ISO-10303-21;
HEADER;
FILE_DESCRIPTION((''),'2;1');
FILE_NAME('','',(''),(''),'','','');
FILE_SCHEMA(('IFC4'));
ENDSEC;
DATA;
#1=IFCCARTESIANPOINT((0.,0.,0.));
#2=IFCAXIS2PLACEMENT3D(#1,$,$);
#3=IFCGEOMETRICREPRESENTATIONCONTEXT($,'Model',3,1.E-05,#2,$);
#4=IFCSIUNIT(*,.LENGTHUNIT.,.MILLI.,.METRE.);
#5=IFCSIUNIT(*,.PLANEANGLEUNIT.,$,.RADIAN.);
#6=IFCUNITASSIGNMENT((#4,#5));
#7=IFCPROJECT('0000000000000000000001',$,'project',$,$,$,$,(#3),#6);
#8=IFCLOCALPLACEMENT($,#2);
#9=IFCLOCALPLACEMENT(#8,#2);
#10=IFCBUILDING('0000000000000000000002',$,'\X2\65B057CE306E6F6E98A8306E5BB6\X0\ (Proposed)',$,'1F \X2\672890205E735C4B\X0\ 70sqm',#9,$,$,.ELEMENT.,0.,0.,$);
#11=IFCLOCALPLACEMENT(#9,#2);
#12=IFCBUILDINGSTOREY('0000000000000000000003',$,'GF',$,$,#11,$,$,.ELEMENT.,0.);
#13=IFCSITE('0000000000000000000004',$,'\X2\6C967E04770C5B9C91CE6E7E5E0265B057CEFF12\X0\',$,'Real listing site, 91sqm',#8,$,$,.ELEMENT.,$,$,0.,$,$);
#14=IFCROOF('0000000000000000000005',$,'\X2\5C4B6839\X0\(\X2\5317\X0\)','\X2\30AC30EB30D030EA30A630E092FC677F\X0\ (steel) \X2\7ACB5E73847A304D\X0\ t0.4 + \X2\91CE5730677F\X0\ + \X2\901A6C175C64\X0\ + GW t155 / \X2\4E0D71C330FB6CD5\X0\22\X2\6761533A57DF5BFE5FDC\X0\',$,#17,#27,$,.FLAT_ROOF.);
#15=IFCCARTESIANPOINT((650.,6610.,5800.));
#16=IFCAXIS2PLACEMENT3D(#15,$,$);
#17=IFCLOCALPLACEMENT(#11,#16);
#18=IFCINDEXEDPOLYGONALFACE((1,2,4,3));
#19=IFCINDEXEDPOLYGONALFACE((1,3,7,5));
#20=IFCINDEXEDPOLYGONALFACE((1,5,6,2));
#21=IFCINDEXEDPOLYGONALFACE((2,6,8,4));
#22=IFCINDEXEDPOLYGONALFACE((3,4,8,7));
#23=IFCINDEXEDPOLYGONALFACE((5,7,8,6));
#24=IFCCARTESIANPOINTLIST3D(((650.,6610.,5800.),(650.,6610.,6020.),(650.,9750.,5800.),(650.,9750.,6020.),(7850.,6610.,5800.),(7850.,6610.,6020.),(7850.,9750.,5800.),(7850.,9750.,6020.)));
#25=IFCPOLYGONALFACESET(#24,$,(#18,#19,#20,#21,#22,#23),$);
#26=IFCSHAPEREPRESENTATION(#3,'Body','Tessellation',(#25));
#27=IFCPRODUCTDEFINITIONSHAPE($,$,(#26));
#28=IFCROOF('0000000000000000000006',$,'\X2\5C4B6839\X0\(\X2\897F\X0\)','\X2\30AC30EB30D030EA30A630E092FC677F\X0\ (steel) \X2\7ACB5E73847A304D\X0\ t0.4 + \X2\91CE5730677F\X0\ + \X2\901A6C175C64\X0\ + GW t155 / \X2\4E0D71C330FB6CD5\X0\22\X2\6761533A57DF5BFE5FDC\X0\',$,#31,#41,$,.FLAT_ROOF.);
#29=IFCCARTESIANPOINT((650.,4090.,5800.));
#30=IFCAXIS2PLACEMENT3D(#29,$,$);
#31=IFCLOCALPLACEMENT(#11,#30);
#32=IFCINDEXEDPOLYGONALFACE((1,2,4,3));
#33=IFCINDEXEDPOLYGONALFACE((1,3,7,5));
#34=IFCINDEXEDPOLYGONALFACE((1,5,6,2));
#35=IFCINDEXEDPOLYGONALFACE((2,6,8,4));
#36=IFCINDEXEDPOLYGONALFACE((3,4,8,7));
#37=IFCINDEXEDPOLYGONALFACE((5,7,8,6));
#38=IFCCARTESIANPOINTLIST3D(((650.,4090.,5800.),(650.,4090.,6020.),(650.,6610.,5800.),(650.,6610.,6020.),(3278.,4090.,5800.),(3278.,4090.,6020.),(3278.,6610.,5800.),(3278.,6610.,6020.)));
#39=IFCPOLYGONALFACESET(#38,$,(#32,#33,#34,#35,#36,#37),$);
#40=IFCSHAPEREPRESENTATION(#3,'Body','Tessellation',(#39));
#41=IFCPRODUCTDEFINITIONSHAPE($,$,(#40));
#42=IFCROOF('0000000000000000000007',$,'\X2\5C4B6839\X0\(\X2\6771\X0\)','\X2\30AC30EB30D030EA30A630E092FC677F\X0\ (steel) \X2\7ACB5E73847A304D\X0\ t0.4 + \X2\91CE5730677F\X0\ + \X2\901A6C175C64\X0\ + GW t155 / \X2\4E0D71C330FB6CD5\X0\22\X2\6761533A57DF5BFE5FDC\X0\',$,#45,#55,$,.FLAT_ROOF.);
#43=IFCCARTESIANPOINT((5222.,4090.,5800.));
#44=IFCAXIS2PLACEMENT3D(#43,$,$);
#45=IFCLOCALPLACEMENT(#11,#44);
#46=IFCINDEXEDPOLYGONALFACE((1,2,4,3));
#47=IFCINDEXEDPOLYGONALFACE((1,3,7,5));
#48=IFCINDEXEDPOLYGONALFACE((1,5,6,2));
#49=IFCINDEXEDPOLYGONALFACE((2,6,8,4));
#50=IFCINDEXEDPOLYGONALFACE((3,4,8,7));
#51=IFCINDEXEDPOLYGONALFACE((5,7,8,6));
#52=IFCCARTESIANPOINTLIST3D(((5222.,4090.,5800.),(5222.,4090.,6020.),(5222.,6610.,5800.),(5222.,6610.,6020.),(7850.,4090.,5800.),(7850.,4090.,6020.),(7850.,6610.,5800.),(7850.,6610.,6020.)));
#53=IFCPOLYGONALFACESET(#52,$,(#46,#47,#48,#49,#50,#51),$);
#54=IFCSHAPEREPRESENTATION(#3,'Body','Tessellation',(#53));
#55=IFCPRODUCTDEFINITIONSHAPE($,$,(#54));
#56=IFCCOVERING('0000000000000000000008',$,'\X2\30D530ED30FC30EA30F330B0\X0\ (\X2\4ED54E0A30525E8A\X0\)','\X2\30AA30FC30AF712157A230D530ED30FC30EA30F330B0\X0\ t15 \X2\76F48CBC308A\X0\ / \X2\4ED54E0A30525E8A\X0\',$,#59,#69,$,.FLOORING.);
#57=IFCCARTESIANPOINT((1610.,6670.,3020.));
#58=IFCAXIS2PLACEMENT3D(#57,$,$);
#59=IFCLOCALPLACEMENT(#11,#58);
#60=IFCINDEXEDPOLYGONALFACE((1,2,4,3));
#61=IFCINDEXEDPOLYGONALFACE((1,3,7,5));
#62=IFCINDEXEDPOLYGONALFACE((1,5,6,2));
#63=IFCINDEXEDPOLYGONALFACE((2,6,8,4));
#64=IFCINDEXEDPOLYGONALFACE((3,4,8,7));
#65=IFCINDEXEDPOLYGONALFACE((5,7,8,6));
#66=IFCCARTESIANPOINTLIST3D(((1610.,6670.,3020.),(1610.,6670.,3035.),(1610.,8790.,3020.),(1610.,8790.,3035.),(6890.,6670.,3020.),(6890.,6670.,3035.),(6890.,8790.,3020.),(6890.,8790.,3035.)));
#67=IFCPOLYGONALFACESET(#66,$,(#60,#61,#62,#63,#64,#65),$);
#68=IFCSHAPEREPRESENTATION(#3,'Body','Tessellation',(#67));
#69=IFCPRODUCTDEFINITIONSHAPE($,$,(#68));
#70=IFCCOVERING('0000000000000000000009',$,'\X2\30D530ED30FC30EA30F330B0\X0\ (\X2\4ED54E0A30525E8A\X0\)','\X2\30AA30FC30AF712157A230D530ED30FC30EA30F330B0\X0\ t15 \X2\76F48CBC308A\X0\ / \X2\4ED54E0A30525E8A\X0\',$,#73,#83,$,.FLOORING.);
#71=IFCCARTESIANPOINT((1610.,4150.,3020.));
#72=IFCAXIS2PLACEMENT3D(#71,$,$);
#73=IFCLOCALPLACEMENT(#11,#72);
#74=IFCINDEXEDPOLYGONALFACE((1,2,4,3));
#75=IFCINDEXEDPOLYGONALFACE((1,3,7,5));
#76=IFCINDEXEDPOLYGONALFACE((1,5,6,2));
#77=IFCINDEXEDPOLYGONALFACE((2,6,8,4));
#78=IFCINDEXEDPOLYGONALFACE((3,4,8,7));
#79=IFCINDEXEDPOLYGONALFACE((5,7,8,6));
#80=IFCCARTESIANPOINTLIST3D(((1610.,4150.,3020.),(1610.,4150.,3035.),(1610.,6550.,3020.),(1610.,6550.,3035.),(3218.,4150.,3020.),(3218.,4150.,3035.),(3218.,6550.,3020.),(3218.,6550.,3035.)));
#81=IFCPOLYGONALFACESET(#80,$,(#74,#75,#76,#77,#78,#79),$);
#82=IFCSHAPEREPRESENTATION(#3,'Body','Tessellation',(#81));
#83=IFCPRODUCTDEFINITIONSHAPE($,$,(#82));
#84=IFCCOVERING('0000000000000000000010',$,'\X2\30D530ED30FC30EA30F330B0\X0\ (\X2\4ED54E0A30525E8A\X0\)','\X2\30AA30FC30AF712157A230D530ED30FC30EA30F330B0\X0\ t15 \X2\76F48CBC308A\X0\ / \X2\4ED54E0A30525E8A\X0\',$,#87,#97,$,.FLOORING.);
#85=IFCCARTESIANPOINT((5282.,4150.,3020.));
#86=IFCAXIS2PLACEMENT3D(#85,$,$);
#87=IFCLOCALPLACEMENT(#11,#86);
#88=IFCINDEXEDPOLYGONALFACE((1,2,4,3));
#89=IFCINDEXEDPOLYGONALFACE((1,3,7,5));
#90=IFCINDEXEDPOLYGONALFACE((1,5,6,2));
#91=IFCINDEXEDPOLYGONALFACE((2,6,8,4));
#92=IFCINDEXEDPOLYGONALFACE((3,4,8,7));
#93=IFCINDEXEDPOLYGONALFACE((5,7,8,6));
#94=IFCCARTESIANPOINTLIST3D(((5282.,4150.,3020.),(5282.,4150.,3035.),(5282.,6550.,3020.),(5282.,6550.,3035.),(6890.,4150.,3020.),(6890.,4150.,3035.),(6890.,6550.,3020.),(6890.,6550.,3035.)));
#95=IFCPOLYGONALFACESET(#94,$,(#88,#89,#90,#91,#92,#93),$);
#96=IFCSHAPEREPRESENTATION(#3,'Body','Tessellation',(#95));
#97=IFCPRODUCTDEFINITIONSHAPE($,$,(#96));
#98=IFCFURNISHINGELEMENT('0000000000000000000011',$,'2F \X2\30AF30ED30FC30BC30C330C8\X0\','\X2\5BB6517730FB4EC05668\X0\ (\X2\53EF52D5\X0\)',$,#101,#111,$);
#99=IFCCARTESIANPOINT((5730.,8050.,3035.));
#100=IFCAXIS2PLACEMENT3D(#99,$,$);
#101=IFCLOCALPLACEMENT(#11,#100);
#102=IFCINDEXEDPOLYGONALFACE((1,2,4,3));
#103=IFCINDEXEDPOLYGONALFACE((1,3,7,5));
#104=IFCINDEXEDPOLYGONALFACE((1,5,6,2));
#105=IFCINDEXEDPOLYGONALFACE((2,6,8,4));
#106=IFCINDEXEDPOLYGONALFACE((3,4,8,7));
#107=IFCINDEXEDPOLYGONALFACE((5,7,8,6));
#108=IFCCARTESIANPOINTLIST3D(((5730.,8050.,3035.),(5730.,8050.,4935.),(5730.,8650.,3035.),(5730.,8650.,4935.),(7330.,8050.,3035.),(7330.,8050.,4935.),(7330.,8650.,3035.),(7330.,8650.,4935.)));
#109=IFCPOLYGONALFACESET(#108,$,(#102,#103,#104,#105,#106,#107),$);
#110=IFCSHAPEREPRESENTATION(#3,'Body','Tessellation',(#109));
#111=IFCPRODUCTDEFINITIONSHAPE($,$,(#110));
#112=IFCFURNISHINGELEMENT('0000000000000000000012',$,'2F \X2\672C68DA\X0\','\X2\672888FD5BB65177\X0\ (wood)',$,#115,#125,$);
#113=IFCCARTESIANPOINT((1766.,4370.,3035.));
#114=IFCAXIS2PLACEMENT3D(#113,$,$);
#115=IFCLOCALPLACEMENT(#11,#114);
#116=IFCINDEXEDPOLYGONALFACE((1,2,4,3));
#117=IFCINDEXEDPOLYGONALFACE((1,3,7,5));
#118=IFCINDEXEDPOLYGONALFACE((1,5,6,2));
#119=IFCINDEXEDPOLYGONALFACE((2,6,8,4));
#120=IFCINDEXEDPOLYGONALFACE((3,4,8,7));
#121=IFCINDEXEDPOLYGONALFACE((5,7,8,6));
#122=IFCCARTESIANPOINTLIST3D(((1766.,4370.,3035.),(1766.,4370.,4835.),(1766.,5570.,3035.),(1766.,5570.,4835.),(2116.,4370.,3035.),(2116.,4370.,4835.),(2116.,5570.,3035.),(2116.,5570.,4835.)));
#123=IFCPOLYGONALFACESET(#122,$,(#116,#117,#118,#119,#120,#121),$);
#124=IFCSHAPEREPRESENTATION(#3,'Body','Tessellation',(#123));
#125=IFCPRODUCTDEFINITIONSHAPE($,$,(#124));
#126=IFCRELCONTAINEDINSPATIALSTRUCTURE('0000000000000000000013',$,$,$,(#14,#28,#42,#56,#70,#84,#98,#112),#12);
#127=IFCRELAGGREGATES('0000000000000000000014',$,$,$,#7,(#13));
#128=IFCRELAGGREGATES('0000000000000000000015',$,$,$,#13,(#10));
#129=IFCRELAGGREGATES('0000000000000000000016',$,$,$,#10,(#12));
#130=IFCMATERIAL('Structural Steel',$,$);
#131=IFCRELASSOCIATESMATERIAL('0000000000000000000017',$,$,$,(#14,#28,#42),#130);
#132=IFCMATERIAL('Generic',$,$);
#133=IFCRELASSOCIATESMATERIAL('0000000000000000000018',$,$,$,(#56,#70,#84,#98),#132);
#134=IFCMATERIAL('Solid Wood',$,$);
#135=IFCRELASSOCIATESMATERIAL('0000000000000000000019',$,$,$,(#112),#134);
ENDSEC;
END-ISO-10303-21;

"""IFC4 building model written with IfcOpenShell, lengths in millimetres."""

from ifc_helpers import new_model, si_unit, frame, frame_2d, origin, place, context, project, spatial, rectangle, extrude, material, element, save


model = new_model("IFC4")

# Units and contexts
model_context = context("Model", 3, precision=1e-05, world=origin())
ifc_project = project(units=[si_unit("LENGTHUNIT", "METRE", prefix="MILLI"), si_unit("PLANEANGLEUNIT", "RADIAN")], contexts=[model_context])

# Site, building, storey
site_placement = place(None, origin())
site = spatial("IfcSite", under=ifc_project, at=site_placement, Name="沖縄県宜野湾市新城２", ObjectType="Real listing site, 91sqm", CompositionType="ELEMENT", RefElevation=0.0)
building_placement = place(site_placement, origin())
building = spatial("IfcBuilding", under=site, at=building_placement, Name="新城の潮風の家 (Proposed)", ObjectType="1F 木造平屋 70sqm", CompositionType="ELEMENT", ElevationOfRefHeight=0.0, ElevationOfTerrain=0.0)
storey_placement = place(building_placement, origin())
storey = spatial("IfcBuildingStorey", under=building, at=storey_placement, Name="GF", CompositionType="ELEMENT", Elevation=0.0)

# Shared definitions
ifc_material_1 = material(Name="Solid Wood")

# Shared definitions
ifc_material_2 = material(Name="Generic")

# Roofs
ifc_material_3 = material(Name="Structural Steel")
for number, where, name in (
    (1, (650.0, 6610.0, 5800.0), "屋根(北)"),
):
    element("IfcRoof", number, at=place(storey_placement, frame(where)), inside=storey, material=ifc_material_3, Name=name, Description="ガルバリウム鋼板 (steel) 立平葺き t0.4 + 野地板 + 通気層 + GW t155 / 不燃・法22条区域対応", PredefinedType="FLAT_ROOF", context=model_context, shape_type="SweptSolid", body=[
        extrude(rectangle(XDim=7200.0, YDim=3140.0, at=frame_2d((3600.0, 1570.0))), frame((650.0, 6610.0, 5800.0)), (0.0, 0.0, 1.0), 220.0),
    ])
roof_1_placement = place(storey_placement, frame((650.0, 4090.0, 5800.0)))
element("IfcRoof", 2, at=roof_1_placement, inside=storey, material=ifc_material_3, Name="屋根(西)", Description="ガルバリウム鋼板 (steel) 立平葺き t0.4 + 野地板 + 通気層 + GW t155 / 不燃・法22条区域対応", PredefinedType="FLAT_ROOF", context=model_context, shape_type="SweptSolid", body=[
    extrude(rectangle(XDim=2628.0, YDim=2520.0, at=frame_2d((1314.0, 1260.0))), frame((650.0, 4090.0, 5800.0)), (0.0, 0.0, 1.0), 220.0),
])
roof_2_placement = place(storey_placement, frame((5222.0, 4090.0, 5800.0)))
element("IfcRoof", 3, at=roof_2_placement, inside=storey, material=ifc_material_3, Name="屋根(東)", Description="ガルバリウム鋼板 (steel) 立平葺き t0.4 + 野地板 + 通気層 + GW t155 / 不燃・法22条区域対応", PredefinedType="FLAT_ROOF", context=model_context, shape_type="SweptSolid", body=[
    extrude(rectangle(XDim=2628.0, YDim=2520.0, at=frame_2d((1314.0, 1260.0))), frame((5222.0, 4090.0, 5800.0)), (0.0, 0.0, 1.0), 220.0),
])

# Coverings
covering_1_placement = place(storey_placement, frame((1610.0, 6670.0, 3020.0)))
element("IfcCovering", 4, at=covering_1_placement, inside=storey, material=ifc_material_2, Name="フローリング (仕上げ床)", Description="オーク無垢フローリング t15 直貼り / 仕上げ床", PredefinedType="FLOORING", context=model_context, shape_type="SweptSolid", body=[
    extrude(rectangle(XDim=5280.0, YDim=2120.0, at=frame_2d((2640.0, 1060.0))), frame((1610.0, 6670.0, 3020.0)), (0.0, 0.0, 1.0), 15.0),
])
covering_2_placement = place(storey_placement, frame((1610.0, 4150.0, 3020.0)))
element("IfcCovering", 5, at=covering_2_placement, inside=storey, material=ifc_material_2, Name="フローリング (仕上げ床)", Description="オーク無垢フローリング t15 直貼り / 仕上げ床", PredefinedType="FLOORING", context=model_context, shape_type="SweptSolid", body=[
    extrude(rectangle(XDim=1608.0, YDim=2400.0, at=frame_2d((804.0, 1200.0))), frame((1610.0, 4150.0, 3020.0)), (0.0, 0.0, 1.0), 15.0),
])
covering_3_placement = place(storey_placement, frame((5282.0, 4150.0, 3020.0)))
element("IfcCovering", 6, at=covering_3_placement, inside=storey, material=ifc_material_2, Name="フローリング (仕上げ床)", Description="オーク無垢フローリング t15 直貼り / 仕上げ床", PredefinedType="FLOORING", context=model_context, shape_type="SweptSolid", body=[
    extrude(rectangle(XDim=1608.0, YDim=2400.0, at=frame_2d((804.0, 1200.0))), frame((5282.0, 4150.0, 3020.0)), (0.0, 0.0, 1.0), 15.0),
])

# Furnishing elements
furnishing_1_placement = place(storey_placement, frame((5730.0, 8050.0, 3035.0)))
element("IfcFurnishingElement", 7, at=furnishing_1_placement, inside=storey, material=ifc_material_2, Name="2F クローゼット", Description="家具・什器 (可動)", context=model_context, shape_type="SweptSolid", body=[
    extrude(rectangle(XDim=1600.0, YDim=600.0, at=frame_2d((800.0, 300.0))), frame((5730.0, 8050.0, 3035.0)), (0.0, 0.0, 1.0), 1900.0),
])
furnishing_2_placement = place(storey_placement, frame((1766.0, 4370.0, 3035.0)))
element("IfcFurnishingElement", 8, at=furnishing_2_placement, inside=storey, material=ifc_material_1, Name="2F 本棚", Description="木製家具 (wood)", context=model_context, shape_type="SweptSolid", body=[
    extrude(rectangle(XDim=350.0, YDim=1200.0, at=frame_2d((175.0, 600.0))), frame((1766.0, 4370.0, 3035.0)), (0.0, 0.0, 1.0), 1800.0),
])

save(model, "model.ifc")
